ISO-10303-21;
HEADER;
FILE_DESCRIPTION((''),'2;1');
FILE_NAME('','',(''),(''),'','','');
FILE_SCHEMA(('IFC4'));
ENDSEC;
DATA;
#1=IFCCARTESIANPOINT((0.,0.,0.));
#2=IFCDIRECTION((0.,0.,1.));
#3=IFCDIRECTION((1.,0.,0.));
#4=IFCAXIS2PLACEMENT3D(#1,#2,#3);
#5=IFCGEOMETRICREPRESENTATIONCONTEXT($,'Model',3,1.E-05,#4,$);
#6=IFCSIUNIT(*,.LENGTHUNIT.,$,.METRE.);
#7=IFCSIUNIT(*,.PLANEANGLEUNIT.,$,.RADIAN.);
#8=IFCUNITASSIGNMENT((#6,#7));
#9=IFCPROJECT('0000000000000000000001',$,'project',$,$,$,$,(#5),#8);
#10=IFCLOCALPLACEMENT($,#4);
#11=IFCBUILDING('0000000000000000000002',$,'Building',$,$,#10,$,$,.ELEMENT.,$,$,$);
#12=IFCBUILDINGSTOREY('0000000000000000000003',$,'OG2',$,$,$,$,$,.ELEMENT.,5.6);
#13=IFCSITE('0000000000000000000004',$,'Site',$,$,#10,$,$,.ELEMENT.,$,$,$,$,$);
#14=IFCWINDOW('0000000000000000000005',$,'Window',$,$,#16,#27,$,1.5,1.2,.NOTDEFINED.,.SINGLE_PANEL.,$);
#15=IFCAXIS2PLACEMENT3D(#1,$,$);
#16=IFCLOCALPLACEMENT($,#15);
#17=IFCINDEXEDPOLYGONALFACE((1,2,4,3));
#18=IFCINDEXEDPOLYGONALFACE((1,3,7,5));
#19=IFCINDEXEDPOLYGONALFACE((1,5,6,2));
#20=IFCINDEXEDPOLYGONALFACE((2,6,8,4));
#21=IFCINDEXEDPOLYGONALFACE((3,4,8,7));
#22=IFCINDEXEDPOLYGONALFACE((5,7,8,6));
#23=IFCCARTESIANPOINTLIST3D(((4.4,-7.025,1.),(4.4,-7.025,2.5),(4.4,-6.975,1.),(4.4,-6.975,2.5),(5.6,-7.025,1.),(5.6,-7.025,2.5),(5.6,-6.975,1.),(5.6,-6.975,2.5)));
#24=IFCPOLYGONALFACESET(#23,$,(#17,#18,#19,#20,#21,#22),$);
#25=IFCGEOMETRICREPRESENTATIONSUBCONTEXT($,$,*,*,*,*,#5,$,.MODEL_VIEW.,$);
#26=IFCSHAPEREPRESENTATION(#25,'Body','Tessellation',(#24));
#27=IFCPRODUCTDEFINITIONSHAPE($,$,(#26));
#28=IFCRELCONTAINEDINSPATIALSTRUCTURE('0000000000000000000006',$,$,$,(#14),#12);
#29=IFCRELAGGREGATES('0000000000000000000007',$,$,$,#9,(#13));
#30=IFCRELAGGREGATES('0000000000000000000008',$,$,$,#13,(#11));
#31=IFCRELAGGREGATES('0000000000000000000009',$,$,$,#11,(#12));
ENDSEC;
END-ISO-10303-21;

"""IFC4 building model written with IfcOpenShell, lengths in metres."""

from ifc_helpers import new_model, si_unit, frame, origin, origin_with_axes, origin_2d, place, context, subcontext, project, spatial, rectangle, extrude, element, save


model = new_model("IFC4")

# Units and contexts
model_context = context("Model", 3, precision=1e-05, world=origin_with_axes())
sub_context = subcontext(model_context, None, None, "MODEL_VIEW")
ifc_project = project(units=[si_unit("LENGTHUNIT", "METRE"), si_unit("PLANEANGLEUNIT", "RADIAN")], contexts=[model_context])

# Site, building, storey
placement_1 = place(None, origin_with_axes())
site = spatial("IfcSite", under=ifc_project, at=placement_1, Name="Site", CompositionType="ELEMENT")
building = spatial("IfcBuilding", under=site, at=placement_1, Name="Building", CompositionType="ELEMENT")
storey = spatial("IfcBuildingStorey", under=building, Name="OG2", CompositionType="ELEMENT", Elevation=5.6)

# Window
placement_2 = place(None, origin_with_axes())
window_placement = place(placement_2, frame((5.0, -7.0, 1.0)))
element("IfcWindow", 1, at=window_placement, inside=storey, Name="Window", OverallHeight=1.5, OverallWidth=1.2, PartitioningType="SINGLE_PANEL", PredefinedType="NOTDEFINED", context=sub_context, shape_type="SweptSolid", body=[
    extrude(rectangle(XDim=1.2, YDim=0.05, at=origin_2d()), origin(), (0.0, 0.0, 1.0), 1.5),
])

save(model, "model.ifc")
